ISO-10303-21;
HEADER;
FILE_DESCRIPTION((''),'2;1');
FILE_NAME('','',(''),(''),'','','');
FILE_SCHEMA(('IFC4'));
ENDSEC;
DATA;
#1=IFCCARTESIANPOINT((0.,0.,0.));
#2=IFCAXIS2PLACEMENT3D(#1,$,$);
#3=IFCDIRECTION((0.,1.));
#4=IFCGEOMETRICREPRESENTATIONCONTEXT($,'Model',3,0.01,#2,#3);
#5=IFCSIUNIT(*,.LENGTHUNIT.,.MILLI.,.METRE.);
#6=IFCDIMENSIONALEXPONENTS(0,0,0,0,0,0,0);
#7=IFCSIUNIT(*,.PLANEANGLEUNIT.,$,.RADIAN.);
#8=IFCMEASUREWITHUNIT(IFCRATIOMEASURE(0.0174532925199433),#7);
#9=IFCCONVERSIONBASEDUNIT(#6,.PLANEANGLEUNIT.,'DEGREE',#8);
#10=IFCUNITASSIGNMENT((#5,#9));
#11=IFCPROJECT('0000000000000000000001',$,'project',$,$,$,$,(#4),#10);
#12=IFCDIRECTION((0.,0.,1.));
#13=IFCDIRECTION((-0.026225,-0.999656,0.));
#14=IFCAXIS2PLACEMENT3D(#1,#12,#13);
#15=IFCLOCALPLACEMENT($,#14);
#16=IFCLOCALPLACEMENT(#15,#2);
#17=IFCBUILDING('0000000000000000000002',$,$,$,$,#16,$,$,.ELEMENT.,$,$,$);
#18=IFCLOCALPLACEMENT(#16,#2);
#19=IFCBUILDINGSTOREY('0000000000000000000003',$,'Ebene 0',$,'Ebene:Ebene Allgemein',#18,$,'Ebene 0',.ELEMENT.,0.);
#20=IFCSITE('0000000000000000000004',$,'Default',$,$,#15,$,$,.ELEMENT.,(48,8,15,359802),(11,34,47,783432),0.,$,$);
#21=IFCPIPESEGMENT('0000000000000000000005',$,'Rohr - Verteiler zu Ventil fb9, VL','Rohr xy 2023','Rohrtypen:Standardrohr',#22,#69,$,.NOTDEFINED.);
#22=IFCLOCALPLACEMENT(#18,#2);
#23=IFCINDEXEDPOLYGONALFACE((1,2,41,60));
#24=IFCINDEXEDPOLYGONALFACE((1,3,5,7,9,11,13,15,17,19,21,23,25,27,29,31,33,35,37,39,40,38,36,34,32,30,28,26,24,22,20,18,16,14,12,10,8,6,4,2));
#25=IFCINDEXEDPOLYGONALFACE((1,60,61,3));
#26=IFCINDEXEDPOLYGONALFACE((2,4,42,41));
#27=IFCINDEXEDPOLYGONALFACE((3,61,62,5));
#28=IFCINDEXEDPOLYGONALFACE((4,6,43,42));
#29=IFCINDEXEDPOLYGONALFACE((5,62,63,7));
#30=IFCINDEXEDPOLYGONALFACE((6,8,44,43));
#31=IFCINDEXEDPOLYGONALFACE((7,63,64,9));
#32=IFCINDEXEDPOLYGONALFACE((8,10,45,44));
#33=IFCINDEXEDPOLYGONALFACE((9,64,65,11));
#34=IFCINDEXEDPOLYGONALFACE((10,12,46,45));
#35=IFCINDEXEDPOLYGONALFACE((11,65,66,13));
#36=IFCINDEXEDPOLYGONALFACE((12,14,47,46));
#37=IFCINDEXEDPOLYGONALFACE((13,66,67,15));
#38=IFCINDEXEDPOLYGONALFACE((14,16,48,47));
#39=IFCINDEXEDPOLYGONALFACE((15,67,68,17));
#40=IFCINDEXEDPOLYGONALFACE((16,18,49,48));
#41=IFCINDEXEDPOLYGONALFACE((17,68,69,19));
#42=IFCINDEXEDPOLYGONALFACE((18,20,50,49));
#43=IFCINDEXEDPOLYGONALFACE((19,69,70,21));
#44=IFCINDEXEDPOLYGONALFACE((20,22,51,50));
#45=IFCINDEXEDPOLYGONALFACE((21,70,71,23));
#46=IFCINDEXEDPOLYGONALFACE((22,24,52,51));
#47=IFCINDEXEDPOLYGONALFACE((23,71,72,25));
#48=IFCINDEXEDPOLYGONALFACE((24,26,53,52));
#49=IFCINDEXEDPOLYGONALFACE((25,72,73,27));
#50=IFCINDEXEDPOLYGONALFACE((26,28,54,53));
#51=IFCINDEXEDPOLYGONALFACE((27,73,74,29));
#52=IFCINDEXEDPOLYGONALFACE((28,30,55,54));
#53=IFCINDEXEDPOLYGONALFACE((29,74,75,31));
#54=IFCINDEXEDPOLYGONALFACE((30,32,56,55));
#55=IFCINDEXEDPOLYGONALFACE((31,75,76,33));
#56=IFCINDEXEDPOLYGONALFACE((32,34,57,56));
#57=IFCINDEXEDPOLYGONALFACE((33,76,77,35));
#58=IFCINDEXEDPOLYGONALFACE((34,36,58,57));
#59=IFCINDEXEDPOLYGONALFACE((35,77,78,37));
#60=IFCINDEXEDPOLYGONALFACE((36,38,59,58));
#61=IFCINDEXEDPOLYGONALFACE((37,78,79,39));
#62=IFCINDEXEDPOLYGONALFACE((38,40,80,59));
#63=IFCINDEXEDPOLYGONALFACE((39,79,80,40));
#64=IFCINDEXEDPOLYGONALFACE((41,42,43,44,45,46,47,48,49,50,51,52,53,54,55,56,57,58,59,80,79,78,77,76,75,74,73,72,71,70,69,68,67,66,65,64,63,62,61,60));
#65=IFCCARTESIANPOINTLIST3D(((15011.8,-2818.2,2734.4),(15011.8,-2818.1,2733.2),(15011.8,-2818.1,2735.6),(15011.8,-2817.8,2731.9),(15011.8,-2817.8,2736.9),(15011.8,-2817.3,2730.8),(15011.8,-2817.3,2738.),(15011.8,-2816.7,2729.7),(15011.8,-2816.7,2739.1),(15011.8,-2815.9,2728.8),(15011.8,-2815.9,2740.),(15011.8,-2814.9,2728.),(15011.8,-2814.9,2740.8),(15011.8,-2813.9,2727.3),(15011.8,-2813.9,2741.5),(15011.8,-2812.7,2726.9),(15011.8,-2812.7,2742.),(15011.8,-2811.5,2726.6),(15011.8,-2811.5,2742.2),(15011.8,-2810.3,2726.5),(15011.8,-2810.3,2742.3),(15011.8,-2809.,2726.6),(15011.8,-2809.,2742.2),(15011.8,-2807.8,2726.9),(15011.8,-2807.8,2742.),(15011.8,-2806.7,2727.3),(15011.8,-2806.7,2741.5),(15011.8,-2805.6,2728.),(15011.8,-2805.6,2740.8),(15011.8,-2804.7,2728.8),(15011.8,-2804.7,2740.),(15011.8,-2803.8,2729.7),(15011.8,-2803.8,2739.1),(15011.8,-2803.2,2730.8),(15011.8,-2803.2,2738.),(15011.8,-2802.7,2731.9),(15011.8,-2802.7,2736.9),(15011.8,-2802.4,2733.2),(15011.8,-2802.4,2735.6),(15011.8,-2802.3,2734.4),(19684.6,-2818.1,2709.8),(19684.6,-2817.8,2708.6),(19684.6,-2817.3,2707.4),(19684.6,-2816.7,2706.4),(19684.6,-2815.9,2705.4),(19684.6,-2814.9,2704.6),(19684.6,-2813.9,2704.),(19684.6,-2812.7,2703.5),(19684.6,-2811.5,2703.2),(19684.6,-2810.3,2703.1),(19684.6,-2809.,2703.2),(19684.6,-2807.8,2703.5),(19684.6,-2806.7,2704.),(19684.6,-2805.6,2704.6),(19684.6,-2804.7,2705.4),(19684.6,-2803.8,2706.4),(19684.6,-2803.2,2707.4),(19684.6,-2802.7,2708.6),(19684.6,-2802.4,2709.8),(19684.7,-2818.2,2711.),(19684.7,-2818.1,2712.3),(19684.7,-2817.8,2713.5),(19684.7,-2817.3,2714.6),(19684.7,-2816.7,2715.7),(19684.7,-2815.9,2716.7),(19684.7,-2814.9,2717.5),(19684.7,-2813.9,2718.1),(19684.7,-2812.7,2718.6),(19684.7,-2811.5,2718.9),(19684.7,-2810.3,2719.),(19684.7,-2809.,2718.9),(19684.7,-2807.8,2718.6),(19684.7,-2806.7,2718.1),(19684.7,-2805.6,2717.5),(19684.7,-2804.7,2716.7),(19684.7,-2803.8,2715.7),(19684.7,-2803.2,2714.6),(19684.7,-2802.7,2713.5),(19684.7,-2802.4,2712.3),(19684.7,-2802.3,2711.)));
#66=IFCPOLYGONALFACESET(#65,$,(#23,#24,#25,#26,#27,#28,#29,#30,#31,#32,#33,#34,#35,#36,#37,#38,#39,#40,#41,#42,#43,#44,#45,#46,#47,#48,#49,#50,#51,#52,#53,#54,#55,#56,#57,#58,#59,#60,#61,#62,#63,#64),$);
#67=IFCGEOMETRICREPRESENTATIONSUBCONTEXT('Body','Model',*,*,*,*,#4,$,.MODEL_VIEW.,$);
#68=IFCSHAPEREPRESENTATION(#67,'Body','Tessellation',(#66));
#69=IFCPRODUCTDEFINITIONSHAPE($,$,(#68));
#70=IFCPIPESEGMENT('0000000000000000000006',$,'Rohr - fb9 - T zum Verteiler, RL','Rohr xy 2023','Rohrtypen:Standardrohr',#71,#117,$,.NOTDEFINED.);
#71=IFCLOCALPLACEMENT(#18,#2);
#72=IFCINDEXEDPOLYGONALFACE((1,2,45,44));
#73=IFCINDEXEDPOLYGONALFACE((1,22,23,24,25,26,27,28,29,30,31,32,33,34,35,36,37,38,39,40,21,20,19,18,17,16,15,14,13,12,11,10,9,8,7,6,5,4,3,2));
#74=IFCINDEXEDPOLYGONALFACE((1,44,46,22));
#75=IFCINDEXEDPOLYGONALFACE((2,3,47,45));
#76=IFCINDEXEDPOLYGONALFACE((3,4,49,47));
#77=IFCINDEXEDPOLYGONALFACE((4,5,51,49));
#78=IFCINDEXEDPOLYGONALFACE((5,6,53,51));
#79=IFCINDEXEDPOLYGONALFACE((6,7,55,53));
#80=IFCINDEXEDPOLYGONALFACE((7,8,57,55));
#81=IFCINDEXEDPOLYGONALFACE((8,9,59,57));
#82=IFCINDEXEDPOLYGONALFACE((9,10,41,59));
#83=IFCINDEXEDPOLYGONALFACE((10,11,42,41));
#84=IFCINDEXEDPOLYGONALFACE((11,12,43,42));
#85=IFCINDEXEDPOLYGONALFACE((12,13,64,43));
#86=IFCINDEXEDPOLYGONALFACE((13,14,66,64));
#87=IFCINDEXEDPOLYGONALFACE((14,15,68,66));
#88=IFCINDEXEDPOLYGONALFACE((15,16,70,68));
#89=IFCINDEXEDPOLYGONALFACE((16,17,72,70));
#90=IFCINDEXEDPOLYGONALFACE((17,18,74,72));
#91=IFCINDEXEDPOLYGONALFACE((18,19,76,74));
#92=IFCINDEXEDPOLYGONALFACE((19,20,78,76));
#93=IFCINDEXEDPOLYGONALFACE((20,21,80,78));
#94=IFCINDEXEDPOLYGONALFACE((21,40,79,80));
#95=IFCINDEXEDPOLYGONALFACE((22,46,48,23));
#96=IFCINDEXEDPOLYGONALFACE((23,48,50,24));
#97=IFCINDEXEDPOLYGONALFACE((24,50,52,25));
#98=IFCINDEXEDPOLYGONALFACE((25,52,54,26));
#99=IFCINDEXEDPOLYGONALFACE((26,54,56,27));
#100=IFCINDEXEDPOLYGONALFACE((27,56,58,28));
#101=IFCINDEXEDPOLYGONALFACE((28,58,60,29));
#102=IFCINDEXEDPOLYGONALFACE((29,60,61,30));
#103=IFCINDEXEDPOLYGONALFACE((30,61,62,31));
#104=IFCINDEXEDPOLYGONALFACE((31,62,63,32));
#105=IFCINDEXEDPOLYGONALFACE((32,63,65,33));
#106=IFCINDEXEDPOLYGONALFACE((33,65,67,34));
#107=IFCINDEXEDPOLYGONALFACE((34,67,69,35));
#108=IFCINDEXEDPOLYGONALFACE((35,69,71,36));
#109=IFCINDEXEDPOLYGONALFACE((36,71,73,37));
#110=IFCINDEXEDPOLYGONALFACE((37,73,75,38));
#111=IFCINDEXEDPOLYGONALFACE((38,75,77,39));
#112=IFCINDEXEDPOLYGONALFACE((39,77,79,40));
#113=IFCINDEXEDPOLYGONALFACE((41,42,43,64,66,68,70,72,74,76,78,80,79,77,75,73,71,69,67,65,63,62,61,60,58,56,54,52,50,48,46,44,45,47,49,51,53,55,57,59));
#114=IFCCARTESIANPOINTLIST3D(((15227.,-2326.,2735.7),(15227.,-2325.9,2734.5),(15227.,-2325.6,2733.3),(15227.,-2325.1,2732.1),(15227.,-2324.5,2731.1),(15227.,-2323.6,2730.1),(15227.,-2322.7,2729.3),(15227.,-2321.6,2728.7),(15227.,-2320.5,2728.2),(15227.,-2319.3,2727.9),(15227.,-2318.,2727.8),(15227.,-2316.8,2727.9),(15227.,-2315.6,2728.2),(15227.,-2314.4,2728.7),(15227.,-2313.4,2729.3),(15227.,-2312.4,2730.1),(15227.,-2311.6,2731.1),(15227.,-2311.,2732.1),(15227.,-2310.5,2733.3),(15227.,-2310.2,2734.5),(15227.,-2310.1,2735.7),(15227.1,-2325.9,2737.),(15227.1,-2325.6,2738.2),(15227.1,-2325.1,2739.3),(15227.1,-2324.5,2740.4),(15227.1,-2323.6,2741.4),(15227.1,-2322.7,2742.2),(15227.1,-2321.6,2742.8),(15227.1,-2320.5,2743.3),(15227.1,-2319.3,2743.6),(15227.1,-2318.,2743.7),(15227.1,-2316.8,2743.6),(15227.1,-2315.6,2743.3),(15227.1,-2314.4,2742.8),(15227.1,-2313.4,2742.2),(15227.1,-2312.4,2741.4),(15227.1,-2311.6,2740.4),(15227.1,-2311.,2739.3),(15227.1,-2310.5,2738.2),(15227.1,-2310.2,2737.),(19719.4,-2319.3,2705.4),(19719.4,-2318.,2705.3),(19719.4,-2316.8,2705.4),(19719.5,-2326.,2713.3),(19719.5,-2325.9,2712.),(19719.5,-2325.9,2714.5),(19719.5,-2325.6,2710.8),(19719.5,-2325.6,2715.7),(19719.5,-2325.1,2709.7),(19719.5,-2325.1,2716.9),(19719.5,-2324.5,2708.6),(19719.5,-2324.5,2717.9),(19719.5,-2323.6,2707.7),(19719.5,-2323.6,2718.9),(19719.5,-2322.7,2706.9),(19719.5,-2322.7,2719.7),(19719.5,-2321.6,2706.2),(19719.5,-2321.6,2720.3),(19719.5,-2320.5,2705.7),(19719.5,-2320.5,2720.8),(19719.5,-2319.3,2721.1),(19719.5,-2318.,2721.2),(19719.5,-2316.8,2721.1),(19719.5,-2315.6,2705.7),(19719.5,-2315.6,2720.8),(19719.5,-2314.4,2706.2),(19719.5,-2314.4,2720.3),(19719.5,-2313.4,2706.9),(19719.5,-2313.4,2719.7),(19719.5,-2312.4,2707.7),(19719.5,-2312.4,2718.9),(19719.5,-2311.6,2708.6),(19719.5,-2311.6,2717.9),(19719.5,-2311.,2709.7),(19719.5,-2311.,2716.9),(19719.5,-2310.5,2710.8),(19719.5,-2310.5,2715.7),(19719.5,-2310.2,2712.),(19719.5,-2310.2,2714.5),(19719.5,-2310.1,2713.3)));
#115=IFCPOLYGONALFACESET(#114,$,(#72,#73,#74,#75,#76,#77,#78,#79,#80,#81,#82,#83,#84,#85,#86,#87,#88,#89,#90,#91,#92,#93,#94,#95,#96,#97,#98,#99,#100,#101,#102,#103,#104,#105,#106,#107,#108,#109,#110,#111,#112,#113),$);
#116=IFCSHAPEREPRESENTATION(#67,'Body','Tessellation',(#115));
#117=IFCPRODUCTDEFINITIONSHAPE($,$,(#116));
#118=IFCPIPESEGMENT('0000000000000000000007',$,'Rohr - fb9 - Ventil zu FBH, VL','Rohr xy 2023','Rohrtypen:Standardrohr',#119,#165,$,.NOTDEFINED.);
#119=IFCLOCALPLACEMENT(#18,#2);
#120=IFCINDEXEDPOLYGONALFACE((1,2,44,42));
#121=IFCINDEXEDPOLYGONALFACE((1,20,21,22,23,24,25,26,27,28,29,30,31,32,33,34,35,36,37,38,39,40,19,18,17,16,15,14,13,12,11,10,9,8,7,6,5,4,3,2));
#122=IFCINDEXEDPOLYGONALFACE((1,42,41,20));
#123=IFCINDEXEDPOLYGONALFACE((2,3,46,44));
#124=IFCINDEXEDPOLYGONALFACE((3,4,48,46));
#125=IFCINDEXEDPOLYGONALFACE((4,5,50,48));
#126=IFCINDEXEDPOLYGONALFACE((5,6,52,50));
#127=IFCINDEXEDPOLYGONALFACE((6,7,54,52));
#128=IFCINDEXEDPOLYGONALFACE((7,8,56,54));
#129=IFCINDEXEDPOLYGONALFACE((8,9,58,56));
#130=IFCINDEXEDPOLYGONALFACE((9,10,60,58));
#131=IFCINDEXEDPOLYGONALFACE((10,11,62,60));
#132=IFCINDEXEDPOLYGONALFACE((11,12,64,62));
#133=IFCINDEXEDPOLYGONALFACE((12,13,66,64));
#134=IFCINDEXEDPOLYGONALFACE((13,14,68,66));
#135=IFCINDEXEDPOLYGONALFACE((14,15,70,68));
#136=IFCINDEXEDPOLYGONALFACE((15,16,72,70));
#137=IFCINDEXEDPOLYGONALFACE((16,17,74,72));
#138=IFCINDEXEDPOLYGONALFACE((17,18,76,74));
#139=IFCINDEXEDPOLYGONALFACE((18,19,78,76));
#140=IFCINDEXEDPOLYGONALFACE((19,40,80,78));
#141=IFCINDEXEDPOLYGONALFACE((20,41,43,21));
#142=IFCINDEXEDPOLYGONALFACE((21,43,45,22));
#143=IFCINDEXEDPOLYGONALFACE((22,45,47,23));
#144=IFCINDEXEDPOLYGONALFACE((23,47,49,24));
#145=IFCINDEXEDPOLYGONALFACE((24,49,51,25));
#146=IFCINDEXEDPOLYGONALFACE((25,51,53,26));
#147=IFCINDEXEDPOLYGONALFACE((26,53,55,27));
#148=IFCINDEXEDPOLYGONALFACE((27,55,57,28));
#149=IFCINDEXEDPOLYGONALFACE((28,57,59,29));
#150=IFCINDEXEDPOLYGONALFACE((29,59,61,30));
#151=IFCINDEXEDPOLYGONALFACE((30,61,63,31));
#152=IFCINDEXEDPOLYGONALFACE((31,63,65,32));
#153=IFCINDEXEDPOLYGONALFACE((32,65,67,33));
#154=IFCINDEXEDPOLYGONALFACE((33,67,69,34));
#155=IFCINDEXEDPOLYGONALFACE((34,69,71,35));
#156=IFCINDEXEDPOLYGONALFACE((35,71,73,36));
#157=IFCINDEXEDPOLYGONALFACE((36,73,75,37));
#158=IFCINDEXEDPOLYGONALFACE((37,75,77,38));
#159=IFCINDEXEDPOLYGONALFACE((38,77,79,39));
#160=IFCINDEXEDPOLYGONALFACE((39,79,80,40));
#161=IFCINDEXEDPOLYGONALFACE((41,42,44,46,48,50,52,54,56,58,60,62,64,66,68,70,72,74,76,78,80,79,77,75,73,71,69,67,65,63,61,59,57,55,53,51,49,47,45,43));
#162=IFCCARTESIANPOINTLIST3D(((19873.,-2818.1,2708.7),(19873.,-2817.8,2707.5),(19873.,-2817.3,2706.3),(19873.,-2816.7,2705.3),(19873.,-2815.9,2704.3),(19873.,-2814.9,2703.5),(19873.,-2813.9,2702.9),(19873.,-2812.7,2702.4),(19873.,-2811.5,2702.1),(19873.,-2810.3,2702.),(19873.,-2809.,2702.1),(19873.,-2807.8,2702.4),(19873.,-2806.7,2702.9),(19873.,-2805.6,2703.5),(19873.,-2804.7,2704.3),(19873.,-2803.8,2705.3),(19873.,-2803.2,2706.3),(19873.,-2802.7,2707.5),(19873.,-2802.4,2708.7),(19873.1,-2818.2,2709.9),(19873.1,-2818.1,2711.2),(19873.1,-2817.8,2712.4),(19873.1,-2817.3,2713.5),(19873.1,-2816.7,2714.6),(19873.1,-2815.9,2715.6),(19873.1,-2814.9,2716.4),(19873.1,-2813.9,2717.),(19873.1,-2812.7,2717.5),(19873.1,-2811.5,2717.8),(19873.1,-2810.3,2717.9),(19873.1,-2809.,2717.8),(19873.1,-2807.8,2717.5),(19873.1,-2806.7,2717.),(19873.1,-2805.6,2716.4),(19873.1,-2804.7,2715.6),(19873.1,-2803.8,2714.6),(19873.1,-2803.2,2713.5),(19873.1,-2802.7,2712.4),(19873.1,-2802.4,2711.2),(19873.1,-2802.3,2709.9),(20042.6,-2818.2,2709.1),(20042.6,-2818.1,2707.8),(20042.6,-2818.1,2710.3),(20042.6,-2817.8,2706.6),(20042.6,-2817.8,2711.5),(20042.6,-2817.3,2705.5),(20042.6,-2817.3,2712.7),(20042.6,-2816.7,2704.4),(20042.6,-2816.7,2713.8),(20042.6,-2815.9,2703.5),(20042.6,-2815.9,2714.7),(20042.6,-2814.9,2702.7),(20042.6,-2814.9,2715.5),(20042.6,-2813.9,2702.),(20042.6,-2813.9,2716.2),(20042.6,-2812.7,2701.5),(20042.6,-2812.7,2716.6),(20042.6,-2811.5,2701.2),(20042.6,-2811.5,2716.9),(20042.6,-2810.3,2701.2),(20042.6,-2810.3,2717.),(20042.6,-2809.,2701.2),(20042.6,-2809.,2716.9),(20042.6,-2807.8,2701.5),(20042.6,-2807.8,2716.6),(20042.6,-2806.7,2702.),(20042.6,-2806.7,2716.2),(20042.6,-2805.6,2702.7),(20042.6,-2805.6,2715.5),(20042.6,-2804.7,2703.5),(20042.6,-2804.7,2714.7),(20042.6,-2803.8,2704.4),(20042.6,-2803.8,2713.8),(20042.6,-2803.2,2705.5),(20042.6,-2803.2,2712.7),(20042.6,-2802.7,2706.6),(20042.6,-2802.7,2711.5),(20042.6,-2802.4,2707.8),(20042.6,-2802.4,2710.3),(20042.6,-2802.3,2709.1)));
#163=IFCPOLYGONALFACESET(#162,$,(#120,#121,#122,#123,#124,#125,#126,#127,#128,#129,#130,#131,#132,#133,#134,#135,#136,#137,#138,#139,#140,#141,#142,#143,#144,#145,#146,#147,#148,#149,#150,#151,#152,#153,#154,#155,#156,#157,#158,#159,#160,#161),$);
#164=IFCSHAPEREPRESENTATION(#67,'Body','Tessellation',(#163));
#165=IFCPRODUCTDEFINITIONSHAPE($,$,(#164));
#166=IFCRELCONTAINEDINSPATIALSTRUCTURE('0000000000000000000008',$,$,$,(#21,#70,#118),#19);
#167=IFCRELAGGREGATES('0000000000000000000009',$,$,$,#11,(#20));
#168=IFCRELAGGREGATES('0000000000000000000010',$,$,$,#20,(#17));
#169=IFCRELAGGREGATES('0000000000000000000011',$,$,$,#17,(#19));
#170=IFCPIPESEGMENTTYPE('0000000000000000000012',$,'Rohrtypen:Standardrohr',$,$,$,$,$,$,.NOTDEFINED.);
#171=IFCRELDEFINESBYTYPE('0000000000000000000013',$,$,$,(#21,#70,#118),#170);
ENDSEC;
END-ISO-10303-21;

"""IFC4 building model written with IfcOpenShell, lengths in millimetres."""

from ifc_helpers import new_model, entity, si_unit, converted_unit, direction, frame, origin, place, context, subcontext, project, spatial, indexed_curve, outline, extrude, type_object, element, save


model = new_model("IFC4")

# Units and contexts
model_context = context("Model", 3, precision=0.01, world=origin(), true_north=direction((0.0, 1.0)))
body_context = subcontext(model_context, "Body", "Model", "MODEL_VIEW")
ifc_project = project(units=[si_unit("LENGTHUNIT", "METRE", prefix="MILLI"), converted_unit("PLANEANGLEUNIT", "DEGREE", entity("IfcRatioMeasure", 0.0174532925199433), si_unit("PLANEANGLEUNIT", "RADIAN"), dimensions=[0, 0, 0, 0, 0, 0, 0])], contexts=[model_context])

# Site, building, storey
site_placement = place(None, frame((0.0, 0.0, 0.0), z_axis=(0.0, 0.0, 1.0), x_axis=(-0.026225, -0.999656, 0.0)))
site = spatial("IfcSite", under=ifc_project, at=site_placement, Name="Default", CompositionType="ELEMENT", RefLatitude=(48, 8, 15, 359802), RefLongitude=(11, 34, 47, 783432), RefElevation=0.0)
building_placement = place(site_placement, origin())
building = spatial("IfcBuilding", under=site, at=building_placement, CompositionType="ELEMENT")
storey_placement = place(building_placement, origin())
storey = spatial("IfcBuildingStorey", under=building, at=storey_placement, Name="Ebene 0", ObjectType="Ebene:Ebene Allgemein", LongName="Ebene 0", CompositionType="ELEMENT", Elevation=0.0)

# Pipe segments
pipe_segment_type = type_object("IfcPipeSegmentType", Name="Rohrtypen:Standardrohr", PredefinedType="NOTDEFINED")
pipe_segment_1_placement = place(storey_placement, origin())
element("IfcPipeSegment", 1, at=pipe_segment_1_placement, inside=storey, type_object=pipe_segment_type, Name="Rohr - Verteiler zu Ventil fb9, VL", Description="Rohr xy 2023", ObjectType="Rohrtypen:Standardrohr", PredefinedType="NOTDEFINED", context=body_context, shape_type="SweptSolid", body=[
    extrude(outline(indexed_curve([(7.9, 0.0), (7.8, 1.2), (7.6, 2.5), (7.1, 3.6), (6.4, 4.7), (5.6, 5.6), (4.7, 6.4), (3.6, 7.1), (2.5, 7.6), (1.2, 7.8), (0.0, 7.9), (-1.2, 7.8), (-2.5, 7.6), (-3.6, 7.1), (-4.7, 6.4), (-5.6, 5.6), (-6.4, 4.7), (-7.1, 3.6), (-7.6, 2.5), (-7.8, 1.2), (-7.9, 0.0), (-7.8, -1.2), (-7.6, -2.5), (-7.1, -3.6), (-6.4, -4.7), (-5.6, -5.6), (-4.7, -6.4), (-3.6, -7.1), (-2.5, -7.6), (-1.2, -7.8), (0.0, -7.9), (1.2, -7.8), (2.5, -7.6), (3.6, -7.1), (4.7, -6.4), (5.6, -5.6), (6.4, -4.7), (7.1, -3.6), (7.6, -2.5), (7.8, -1.2), (7.9, 0.0)], self_intersect=False)), frame((19684.7, -2810.3, 2711.0), z_axis=(-0.999988, 0.0, 0.005), x_axis=(0.0, 1.0, 0.0)), (0.0, 0.0, 1.0), 4672.9),
])
pipe_segment_2_placement = place(storey_placement, origin())
element("IfcPipeSegment", 2, at=pipe_segment_2_placement, inside=storey, type_object=pipe_segment_type, Name="Rohr - fb9 - T zum Verteiler, RL", Description="Rohr xy 2023", ObjectType="Rohrtypen:Standardrohr", PredefinedType="NOTDEFINED", context=body_context, shape_type="SweptSolid", body=[
    extrude(outline(indexed_curve([(7.9, 0.0), (7.8, 1.2), (7.6, 2.5), (7.1, 3.6), (6.4, 4.7), (5.6, 5.6), (4.7, 6.4), (3.6, 7.1), (2.5, 7.6), (1.2, 7.8), (0.0, 7.9), (-1.2, 7.8), (-2.5, 7.6), (-3.6, 7.1), (-4.7, 6.4), (-5.6, 5.6), (-6.4, 4.7), (-7.1, 3.6), (-7.6, 2.5), (-7.8, 1.2), (-7.9, 0.0), (-7.8, -1.2), (-7.6, -2.5), (-7.1, -3.6), (-6.4, -4.7), (-5.6, -5.6), (-4.7, -6.4), (-3.6, -7.1), (-2.5, -7.6), (-1.2, -7.8), (0.0, -7.9), (1.2, -7.8), (2.5, -7.6), (3.6, -7.1), (4.7, -6.4), (5.6, -5.6), (6.4, -4.7), (7.1, -3.6), (7.6, -2.5), (7.8, -1.2), (7.9, 0.0)], self_intersect=False)), frame((15227.0, -2318.0, 2735.7), z_axis=(0.999988, 0.0, -0.005), x_axis=(0.0, 1.0, 0.0)), (0.0, 0.0, 1.0), 4492.5),
])
pipe_segment_3_placement = place(storey_placement, origin())
element("IfcPipeSegment", 3, at=pipe_segment_3_placement, inside=storey, type_object=pipe_segment_type, Name="Rohr - fb9 - Ventil zu FBH, VL", Description="Rohr xy 2023", ObjectType="Rohrtypen:Standardrohr", PredefinedType="NOTDEFINED", context=body_context, shape_type="SweptSolid", body=[
    extrude(outline(indexed_curve([(7.9, 0.0), (7.8, 1.2), (7.6, 2.5), (7.1, 3.6), (6.4, 4.7), (5.6, 5.6), (4.7, 6.4), (3.6, 7.1), (2.5, 7.6), (1.2, 7.8), (0.0, 7.9), (-1.2, 7.8), (-2.5, 7.6), (-3.6, 7.1), (-4.7, 6.4), (-5.6, 5.6), (-6.4, 4.7), (-7.1, 3.6), (-7.6, 2.5), (-7.8, 1.2), (-7.9, 0.0), (-7.8, -1.2), (-7.6, -2.5), (-7.1, -3.6), (-6.4, -4.7), (-5.6, -5.6), (-4.7, -6.4), (-3.6, -7.1), (-2.5, -7.6), (-1.2, -7.8), (0.0, -7.9), (1.2, -7.8), (2.5, -7.6), (3.6, -7.1), (4.7, -6.4), (5.6, -5.6), (6.4, -4.7), (7.1, -3.6), (7.6, -2.5), (7.8, -1.2), (7.9, 0.0)], self_intersect=False)), frame((19873.1, -2810.3, 2709.9), z_axis=(0.999988, 0.0, -0.005), x_axis=(0.0, 1.0, 0.0)), (0.0, 0.0, 1.0), 169.5),
])

save(model, "model.ifc")
